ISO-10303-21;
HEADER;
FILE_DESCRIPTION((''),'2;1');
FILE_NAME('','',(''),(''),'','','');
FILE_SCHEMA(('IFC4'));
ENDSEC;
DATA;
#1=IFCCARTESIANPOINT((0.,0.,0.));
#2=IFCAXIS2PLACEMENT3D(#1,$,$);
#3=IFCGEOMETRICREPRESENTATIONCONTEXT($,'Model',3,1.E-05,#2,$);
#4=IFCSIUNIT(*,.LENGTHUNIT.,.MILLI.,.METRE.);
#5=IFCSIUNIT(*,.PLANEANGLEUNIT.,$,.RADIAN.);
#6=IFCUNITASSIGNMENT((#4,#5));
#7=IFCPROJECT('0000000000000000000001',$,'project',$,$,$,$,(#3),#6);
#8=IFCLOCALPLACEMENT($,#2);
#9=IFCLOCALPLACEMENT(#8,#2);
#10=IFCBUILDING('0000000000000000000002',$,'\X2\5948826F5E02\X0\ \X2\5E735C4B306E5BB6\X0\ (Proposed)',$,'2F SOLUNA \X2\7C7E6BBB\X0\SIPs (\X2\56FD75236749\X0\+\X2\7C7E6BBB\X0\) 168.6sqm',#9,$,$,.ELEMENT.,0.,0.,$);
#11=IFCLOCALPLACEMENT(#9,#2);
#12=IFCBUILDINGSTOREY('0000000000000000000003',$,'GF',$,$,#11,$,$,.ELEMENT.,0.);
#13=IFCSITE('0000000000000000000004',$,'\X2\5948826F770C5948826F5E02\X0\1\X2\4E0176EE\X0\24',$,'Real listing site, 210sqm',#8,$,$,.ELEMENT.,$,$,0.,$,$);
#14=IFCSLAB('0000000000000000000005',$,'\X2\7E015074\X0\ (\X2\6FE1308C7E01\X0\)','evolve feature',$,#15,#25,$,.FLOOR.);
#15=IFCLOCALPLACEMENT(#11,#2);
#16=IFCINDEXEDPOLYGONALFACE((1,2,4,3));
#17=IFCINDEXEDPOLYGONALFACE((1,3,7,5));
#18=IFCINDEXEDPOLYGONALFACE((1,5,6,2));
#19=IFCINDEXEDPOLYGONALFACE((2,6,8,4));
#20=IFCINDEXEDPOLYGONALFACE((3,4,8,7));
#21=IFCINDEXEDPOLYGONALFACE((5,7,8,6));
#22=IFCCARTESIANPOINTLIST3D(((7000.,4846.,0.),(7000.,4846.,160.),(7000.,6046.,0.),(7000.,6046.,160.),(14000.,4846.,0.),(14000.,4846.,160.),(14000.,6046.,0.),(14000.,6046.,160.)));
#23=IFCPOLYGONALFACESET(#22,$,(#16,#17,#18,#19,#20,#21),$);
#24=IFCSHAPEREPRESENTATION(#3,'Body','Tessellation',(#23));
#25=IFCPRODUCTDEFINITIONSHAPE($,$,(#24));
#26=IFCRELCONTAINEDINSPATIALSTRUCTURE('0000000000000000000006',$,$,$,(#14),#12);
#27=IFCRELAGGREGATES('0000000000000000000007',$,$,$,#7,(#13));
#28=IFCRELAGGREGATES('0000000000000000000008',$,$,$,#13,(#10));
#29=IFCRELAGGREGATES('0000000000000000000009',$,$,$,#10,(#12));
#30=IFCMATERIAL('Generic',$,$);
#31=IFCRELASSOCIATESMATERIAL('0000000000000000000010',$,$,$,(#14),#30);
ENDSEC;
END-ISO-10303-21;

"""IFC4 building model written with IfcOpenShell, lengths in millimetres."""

from ifc_helpers import new_model, si_unit, frame, frame_2d, origin, place, context, project, spatial, rectangle, extrude, material, element, save


model = new_model("IFC4")

# Units and contexts
model_context = context("Model", 3, precision=1e-05, world=origin())
ifc_project = project(units=[si_unit("LENGTHUNIT", "METRE", prefix="MILLI"), si_unit("PLANEANGLEUNIT", "RADIAN")], contexts=[model_context])

# Site, building, storey
site_placement = place(None, origin())
site = spatial("IfcSite", under=ifc_project, at=site_placement, Name="奈良県奈良市1丁目24", ObjectType="Real listing site, 210sqm", CompositionType="ELEMENT", RefElevation=0.0)
building_placement = place(site_placement, origin())
building = spatial("IfcBuilding", under=site, at=building_placement, Name="奈良市 平屋の家 (Proposed)", ObjectType="2F SOLUNA 籾殻SIPs (国産杉+籾殻) 168.6sqm", CompositionType="ELEMENT", ElevationOfRefHeight=0.0, ElevationOfTerrain=0.0)
storey_placement = place(building_placement, origin())
storey = spatial("IfcBuildingStorey", under=building, at=storey_placement, Name="GF", CompositionType="ELEMENT", Elevation=0.0)

# Slab
ifc_material_1 = material(Name="Generic")
slab_1_placement = place(storey_placement, frame((3500.0, 2423.0, 0.0)))
element("IfcSlab", 1, at=slab_1_placement, inside=storey, material=ifc_material_1, Name="縁側 (濡れ縁)", Description="evolve feature", PredefinedType="FLOOR", context=model_context, shape_type="SweptSolid", body=[
    extrude(rectangle(XDim=7000.0, YDim=1200.0, at=frame_2d((3500.0, 600.0))), frame((3500.0, 2423.0, 0.0)), (0.0, 0.0, 1.0), 160.0),
])

save(model, "model.ifc")
